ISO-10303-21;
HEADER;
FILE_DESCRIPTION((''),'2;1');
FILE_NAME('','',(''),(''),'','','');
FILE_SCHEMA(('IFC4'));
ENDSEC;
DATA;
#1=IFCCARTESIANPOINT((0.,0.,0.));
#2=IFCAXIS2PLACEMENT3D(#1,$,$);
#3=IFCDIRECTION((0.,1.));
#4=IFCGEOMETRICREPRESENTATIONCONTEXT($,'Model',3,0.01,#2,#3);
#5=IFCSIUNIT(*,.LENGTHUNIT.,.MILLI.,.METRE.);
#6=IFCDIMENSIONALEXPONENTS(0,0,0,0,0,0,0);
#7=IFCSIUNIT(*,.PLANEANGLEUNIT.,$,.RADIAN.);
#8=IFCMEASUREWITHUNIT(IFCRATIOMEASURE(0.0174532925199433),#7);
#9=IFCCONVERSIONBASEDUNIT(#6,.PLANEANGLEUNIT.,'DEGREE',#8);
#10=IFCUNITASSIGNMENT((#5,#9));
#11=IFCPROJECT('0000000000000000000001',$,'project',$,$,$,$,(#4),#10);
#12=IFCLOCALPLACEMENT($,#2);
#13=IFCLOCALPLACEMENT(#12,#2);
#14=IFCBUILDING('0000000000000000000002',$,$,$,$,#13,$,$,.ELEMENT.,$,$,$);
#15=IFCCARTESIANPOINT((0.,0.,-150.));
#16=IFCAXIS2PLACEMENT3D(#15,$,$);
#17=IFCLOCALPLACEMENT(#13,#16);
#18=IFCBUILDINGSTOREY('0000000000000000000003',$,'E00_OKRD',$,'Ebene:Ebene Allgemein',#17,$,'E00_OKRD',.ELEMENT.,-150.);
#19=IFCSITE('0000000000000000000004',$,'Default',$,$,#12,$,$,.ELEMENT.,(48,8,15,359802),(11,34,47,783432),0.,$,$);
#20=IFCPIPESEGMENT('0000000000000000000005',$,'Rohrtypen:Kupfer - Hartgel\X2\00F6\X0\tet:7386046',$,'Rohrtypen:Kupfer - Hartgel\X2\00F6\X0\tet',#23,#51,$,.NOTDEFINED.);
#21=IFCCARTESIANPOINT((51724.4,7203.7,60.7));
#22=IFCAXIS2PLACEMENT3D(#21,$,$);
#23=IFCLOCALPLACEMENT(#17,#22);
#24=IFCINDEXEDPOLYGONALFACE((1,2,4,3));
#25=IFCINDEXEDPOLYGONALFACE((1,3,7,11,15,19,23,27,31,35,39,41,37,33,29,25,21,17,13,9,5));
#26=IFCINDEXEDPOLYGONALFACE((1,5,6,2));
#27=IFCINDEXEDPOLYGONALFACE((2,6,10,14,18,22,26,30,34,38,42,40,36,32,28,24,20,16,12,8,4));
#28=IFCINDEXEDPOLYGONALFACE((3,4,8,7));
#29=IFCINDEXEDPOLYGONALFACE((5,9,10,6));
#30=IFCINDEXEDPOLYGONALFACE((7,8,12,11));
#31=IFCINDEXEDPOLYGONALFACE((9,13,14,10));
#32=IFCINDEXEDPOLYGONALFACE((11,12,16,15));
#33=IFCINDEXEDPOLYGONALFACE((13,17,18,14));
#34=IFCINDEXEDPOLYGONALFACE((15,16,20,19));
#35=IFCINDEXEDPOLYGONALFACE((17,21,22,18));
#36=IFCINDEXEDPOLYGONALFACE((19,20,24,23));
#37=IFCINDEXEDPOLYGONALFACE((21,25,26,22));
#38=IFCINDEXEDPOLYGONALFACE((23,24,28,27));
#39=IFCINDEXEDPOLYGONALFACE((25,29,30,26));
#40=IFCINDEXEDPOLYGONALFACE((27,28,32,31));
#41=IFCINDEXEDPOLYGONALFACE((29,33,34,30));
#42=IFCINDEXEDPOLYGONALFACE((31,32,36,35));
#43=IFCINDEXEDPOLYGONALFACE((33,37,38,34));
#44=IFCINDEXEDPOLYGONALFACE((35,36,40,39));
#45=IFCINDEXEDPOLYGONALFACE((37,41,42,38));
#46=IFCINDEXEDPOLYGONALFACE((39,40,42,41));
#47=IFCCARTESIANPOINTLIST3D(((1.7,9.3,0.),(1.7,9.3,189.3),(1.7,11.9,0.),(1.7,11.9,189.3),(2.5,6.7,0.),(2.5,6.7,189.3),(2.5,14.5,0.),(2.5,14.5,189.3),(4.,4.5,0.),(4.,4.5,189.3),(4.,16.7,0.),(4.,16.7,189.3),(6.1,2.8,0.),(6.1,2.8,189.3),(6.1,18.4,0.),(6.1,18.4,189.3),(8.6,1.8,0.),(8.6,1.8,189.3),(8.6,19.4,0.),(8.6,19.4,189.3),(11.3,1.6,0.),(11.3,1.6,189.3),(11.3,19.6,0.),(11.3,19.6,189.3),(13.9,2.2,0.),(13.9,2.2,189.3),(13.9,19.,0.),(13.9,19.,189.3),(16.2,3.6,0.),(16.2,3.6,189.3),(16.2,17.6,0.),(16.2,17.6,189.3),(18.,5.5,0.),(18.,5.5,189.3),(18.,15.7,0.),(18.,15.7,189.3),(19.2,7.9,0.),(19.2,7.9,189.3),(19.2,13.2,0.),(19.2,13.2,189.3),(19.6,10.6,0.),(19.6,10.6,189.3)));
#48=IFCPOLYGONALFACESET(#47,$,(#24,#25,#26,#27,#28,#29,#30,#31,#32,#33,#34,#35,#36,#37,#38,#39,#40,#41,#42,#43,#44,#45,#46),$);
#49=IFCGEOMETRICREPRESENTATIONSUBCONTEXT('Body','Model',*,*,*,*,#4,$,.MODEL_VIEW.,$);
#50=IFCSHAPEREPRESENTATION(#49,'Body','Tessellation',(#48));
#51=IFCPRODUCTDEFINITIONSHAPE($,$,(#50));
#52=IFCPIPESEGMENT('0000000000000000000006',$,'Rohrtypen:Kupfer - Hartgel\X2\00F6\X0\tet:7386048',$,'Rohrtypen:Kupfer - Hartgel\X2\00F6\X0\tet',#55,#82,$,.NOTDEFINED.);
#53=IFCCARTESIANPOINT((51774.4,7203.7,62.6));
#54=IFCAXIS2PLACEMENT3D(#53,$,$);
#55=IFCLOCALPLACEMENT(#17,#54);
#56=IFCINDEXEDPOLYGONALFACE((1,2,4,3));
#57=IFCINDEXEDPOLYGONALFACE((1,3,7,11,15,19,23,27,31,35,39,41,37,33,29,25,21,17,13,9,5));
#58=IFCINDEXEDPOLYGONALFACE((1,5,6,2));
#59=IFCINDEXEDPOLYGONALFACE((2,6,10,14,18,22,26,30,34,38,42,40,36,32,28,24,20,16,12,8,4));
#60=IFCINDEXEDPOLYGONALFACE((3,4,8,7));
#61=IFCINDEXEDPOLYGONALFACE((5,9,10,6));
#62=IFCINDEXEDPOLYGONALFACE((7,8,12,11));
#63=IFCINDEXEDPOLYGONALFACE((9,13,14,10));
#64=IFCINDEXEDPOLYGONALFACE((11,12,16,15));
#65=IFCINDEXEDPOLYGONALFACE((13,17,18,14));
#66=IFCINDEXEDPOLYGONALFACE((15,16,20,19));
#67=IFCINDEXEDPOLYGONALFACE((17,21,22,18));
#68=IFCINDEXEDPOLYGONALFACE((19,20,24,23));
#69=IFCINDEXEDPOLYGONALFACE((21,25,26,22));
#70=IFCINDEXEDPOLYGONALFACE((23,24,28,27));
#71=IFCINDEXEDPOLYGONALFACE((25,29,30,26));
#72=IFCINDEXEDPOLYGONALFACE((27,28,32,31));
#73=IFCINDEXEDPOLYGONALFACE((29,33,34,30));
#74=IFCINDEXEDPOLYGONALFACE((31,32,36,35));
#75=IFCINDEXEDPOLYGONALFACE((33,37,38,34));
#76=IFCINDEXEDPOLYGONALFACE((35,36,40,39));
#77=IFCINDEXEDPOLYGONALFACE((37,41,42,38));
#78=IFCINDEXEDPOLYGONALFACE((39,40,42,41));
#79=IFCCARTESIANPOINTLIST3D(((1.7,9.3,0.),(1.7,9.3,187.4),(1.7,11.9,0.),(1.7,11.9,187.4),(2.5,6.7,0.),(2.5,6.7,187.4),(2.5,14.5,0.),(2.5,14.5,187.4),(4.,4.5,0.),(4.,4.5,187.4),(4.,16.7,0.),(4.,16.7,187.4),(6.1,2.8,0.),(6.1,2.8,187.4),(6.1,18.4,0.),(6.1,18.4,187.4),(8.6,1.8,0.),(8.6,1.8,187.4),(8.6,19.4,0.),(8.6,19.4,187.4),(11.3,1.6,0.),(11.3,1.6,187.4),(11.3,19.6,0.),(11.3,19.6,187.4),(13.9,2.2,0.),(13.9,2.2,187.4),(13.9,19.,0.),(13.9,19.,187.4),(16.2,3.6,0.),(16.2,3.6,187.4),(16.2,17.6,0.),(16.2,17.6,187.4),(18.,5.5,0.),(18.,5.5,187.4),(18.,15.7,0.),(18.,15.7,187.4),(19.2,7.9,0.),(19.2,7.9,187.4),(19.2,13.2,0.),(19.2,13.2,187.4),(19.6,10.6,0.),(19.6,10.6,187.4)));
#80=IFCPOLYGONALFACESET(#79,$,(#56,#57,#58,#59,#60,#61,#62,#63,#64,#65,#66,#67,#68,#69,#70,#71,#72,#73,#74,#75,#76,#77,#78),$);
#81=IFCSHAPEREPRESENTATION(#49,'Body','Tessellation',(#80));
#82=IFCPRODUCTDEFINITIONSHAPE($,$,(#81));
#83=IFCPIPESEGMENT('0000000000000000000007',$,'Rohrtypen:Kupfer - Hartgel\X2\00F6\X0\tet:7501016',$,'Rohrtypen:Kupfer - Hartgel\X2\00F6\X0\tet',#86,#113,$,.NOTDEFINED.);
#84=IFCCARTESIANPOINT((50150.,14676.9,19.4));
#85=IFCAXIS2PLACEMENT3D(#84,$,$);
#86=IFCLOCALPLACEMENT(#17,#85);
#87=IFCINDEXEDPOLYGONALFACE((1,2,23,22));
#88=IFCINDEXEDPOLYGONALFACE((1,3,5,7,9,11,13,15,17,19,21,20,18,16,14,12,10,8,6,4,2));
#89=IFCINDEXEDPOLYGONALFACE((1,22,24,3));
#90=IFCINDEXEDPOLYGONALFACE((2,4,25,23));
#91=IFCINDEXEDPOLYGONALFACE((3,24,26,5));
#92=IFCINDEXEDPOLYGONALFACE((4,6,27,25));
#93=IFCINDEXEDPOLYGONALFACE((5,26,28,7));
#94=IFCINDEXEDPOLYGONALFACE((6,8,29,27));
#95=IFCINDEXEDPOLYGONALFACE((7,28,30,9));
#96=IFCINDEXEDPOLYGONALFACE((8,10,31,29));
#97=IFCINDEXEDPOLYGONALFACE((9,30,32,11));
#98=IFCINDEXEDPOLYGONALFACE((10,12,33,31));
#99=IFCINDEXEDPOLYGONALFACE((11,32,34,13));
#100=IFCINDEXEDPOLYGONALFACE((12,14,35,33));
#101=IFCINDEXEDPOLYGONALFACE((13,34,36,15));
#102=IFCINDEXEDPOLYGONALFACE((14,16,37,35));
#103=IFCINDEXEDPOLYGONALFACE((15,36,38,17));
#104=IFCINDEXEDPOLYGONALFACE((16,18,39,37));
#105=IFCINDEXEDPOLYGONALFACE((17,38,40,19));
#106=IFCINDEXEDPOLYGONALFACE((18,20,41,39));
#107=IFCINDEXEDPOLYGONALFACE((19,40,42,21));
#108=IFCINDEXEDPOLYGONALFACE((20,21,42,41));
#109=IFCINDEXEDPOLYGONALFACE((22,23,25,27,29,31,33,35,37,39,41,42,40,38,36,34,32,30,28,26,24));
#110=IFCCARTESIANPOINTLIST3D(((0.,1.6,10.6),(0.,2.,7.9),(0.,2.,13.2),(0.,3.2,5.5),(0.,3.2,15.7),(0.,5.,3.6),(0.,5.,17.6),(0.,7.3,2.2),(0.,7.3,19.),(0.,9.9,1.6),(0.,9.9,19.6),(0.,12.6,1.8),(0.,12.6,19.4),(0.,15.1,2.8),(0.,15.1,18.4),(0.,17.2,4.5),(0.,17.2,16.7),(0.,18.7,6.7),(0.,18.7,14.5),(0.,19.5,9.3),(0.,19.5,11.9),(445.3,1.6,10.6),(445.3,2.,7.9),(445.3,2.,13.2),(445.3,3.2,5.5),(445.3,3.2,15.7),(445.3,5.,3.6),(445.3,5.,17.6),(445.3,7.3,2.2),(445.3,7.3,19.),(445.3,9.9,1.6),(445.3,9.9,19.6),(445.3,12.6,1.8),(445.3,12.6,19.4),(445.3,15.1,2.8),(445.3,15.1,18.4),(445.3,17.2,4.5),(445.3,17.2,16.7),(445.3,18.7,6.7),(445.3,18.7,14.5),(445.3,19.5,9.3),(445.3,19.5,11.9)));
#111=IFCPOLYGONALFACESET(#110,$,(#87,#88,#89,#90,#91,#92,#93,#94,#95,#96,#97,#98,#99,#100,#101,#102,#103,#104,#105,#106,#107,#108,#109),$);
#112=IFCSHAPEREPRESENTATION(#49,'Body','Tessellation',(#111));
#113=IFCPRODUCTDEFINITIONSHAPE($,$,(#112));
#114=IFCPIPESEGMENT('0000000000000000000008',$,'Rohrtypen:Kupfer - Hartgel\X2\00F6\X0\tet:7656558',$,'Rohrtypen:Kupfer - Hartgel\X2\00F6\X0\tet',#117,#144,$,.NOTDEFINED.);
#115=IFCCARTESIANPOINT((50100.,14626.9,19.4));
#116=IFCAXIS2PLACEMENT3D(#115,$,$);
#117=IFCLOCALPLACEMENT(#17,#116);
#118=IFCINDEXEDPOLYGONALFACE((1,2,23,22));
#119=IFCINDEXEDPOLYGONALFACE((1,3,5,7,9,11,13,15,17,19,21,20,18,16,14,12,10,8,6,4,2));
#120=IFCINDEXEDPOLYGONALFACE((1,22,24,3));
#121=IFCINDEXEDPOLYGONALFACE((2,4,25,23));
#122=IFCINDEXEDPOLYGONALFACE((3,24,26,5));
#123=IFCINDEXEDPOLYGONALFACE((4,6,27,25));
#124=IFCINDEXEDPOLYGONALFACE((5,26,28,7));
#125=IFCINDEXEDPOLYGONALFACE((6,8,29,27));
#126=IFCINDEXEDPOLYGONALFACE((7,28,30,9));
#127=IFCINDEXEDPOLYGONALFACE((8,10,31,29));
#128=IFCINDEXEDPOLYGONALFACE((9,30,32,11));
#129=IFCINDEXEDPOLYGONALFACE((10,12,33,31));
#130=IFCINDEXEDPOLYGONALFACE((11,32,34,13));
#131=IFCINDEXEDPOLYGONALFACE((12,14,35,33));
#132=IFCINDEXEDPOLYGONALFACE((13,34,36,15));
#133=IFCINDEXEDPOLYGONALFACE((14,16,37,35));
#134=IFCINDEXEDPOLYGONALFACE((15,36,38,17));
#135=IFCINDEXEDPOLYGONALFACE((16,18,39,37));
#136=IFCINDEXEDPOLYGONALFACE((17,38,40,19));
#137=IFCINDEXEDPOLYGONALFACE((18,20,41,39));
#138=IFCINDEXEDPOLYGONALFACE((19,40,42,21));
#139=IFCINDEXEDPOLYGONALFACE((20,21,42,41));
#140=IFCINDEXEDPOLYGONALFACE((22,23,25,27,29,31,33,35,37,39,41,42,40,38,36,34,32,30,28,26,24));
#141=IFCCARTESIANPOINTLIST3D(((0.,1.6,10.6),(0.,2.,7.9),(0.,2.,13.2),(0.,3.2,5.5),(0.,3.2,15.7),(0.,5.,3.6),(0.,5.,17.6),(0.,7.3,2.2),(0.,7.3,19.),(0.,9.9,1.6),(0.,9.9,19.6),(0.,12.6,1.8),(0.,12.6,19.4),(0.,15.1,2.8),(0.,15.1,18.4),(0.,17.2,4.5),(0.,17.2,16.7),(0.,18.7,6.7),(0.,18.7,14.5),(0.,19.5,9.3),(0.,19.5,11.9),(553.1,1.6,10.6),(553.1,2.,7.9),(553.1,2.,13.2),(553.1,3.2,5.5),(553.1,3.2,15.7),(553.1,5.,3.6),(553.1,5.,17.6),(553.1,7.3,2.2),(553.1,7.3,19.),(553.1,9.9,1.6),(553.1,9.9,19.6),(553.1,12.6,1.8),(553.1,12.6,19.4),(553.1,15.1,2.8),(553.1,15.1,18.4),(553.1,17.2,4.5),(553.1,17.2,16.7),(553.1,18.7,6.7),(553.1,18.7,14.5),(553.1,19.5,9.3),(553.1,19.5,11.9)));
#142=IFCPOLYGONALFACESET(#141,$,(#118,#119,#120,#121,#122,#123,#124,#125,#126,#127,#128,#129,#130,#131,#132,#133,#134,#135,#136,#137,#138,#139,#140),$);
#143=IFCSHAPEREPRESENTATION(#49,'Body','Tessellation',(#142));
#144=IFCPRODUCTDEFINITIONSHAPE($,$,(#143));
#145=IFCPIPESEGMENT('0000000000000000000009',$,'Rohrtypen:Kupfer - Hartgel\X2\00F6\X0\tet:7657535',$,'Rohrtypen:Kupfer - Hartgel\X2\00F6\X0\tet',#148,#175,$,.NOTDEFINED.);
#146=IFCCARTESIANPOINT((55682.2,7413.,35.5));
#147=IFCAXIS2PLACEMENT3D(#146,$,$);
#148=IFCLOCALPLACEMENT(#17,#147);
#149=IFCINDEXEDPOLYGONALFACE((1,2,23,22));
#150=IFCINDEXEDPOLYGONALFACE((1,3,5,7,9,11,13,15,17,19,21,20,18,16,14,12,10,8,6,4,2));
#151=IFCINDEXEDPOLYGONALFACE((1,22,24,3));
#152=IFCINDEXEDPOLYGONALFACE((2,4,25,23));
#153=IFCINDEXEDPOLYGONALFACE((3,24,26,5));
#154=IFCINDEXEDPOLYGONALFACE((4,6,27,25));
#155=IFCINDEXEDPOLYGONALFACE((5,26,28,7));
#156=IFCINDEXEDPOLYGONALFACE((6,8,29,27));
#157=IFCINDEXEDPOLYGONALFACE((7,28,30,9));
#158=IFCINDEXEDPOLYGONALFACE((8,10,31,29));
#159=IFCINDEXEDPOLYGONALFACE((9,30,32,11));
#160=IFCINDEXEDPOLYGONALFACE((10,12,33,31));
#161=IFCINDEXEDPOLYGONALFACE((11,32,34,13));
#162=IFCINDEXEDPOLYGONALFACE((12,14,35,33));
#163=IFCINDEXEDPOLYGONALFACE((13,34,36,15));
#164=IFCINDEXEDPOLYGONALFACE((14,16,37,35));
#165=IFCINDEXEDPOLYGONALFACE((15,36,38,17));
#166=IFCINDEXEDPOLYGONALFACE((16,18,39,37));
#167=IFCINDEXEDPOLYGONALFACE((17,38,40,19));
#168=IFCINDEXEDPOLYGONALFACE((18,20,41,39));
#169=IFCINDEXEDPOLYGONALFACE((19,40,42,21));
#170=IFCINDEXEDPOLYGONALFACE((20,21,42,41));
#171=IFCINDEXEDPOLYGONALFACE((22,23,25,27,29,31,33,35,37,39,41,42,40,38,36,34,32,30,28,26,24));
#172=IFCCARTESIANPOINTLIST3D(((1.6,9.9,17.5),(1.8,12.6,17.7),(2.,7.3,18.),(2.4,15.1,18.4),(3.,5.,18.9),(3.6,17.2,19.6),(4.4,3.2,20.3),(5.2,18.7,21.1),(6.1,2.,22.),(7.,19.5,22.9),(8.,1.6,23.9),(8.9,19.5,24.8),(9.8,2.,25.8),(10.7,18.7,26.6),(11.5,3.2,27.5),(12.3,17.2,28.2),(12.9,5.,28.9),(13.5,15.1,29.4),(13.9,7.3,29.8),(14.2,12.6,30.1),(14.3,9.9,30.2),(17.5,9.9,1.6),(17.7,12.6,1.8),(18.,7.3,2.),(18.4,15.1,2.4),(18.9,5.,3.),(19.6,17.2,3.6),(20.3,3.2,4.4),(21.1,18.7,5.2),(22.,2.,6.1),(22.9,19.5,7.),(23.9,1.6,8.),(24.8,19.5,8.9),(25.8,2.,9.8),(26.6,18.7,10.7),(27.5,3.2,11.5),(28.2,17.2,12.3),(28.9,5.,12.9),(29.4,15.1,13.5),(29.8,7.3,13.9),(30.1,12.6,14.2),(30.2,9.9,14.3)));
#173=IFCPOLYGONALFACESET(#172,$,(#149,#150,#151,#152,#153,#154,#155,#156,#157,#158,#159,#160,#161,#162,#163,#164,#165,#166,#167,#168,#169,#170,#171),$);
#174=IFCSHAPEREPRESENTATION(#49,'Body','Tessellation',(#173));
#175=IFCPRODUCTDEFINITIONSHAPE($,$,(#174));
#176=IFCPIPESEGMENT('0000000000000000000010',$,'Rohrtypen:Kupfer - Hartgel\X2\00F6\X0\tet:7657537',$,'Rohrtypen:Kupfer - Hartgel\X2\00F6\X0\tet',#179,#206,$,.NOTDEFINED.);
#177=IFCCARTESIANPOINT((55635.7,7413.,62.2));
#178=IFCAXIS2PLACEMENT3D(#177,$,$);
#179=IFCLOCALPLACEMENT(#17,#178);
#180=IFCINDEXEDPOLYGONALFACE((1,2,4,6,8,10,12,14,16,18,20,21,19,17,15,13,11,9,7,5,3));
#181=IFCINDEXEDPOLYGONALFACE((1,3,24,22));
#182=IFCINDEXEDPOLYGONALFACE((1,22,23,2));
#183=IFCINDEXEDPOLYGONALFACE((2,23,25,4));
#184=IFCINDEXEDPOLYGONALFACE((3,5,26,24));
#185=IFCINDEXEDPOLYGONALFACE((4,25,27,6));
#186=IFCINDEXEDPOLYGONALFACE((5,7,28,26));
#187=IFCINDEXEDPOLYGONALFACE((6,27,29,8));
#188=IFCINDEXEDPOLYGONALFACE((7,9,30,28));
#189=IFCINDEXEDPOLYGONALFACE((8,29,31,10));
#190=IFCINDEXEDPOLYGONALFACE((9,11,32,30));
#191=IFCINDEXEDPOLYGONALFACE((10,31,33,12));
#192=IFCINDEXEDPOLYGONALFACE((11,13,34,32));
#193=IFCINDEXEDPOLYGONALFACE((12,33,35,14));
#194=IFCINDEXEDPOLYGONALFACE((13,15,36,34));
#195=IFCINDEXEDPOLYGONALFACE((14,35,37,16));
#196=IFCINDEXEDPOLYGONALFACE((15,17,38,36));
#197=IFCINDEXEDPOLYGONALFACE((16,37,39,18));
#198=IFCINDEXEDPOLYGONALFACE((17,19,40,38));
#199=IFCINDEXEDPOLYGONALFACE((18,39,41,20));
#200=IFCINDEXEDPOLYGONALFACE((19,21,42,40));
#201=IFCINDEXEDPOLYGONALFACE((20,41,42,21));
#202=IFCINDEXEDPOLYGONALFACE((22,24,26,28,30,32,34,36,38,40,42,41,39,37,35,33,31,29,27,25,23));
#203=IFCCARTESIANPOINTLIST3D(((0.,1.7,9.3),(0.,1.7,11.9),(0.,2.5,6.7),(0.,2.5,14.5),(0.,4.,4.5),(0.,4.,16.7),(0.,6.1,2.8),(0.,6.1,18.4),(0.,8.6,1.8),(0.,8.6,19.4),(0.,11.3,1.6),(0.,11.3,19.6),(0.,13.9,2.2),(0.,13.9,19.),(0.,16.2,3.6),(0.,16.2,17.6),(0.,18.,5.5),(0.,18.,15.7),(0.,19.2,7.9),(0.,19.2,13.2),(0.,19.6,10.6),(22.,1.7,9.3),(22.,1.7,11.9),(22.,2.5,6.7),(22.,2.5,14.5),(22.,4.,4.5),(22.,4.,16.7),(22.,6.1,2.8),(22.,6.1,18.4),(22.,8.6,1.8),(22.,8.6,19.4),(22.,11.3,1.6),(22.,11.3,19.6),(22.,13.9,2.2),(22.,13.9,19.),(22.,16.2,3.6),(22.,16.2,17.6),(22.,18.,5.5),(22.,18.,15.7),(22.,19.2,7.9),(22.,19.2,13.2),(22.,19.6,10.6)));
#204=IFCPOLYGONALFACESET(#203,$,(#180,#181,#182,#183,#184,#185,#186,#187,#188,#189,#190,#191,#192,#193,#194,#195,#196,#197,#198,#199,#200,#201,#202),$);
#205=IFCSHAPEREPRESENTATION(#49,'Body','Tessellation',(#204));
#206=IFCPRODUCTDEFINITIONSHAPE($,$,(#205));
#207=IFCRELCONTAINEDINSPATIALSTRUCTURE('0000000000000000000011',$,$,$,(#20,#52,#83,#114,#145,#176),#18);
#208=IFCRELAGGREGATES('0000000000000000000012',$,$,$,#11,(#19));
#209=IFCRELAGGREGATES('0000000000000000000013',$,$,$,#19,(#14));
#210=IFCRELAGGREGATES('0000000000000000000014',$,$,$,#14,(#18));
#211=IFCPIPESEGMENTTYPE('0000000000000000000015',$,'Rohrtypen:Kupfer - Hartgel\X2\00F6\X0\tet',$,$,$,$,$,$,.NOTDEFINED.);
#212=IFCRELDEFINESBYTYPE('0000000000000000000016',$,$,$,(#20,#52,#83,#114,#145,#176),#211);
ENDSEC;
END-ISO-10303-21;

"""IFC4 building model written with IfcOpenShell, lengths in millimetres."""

from ifc_helpers import new_model, entity, si_unit, converted_unit, direction, frame, frame_2d, origin, origin_2d_with_axis, place, context, subcontext, project, spatial, circle, extrude, type_object, element, save


model = new_model("IFC4")

# Units and contexts
model_context = context("Model", 3, precision=0.01, world=origin(), true_north=direction((0.0, 1.0)))
body_context = subcontext(model_context, "Body", "Model", "MODEL_VIEW")
ifc_project = project(units=[si_unit("LENGTHUNIT", "METRE", prefix="MILLI"), converted_unit("PLANEANGLEUNIT", "DEGREE", entity("IfcRatioMeasure", 0.0174532925199433), si_unit("PLANEANGLEUNIT", "RADIAN"), dimensions=[0, 0, 0, 0, 0, 0, 0])], contexts=[model_context])

# Site, building, storey
site_placement = place(None, origin())
site = spatial("IfcSite", under=ifc_project, at=site_placement, Name="Default", CompositionType="ELEMENT", RefLatitude=(48, 8, 15, 359802), RefLongitude=(11, 34, 47, 783432), RefElevation=0.0)
building_placement = place(site_placement, origin())
building = spatial("IfcBuilding", under=site, at=building_placement, CompositionType="ELEMENT")
storey_placement = place(building_placement, frame((0.0, 0.0, -150.0)))
storey = spatial("IfcBuildingStorey", under=building, at=storey_placement, Name="E00_OKRD", ObjectType="Ebene:Ebene Allgemein", LongName="E00_OKRD", CompositionType="ELEMENT", Elevation=-150.0)

# Pipe segments
pipe_segment_type = type_object("IfcPipeSegmentType", Name="Rohrtypen:Kupfer - Hartgelötet", PredefinedType="NOTDEFINED")
pipe_segment_1_placement = place(storey_placement, frame((51724.4, 7203.7, 60.7)))
element("IfcPipeSegment", 1, at=pipe_segment_1_placement, inside=storey, type_object=pipe_segment_type, Name="Rohrtypen:Kupfer - Hartgelötet:7386046", ObjectType="Rohrtypen:Kupfer - Hartgelötet", PredefinedType="NOTDEFINED", context=body_context, shape_type="SweptSolid", body=[
    extrude(circle(Radius=9.0, at=origin_2d_with_axis()), frame((10.6, 10.6, 0.0)), (0.0, 0.0, 1.0), 189.3),
])
pipe_segment_2_placement = place(storey_placement, frame((51774.4, 7203.7, 62.6)))
element("IfcPipeSegment", 2, at=pipe_segment_2_placement, inside=storey, type_object=pipe_segment_type, Name="Rohrtypen:Kupfer - Hartgelötet:7386048", ObjectType="Rohrtypen:Kupfer - Hartgelötet", PredefinedType="NOTDEFINED", context=body_context, shape_type="SweptSolid", body=[
    extrude(circle(Radius=9.0, at=origin_2d_with_axis()), frame((10.6, 10.6, 0.0)), (0.0, 0.0, 1.0), 187.4),
])
pipe_segment_3_placement = place(storey_placement, frame((50150.0, 14676.9, 19.4)))
element("IfcPipeSegment", 3, at=pipe_segment_3_placement, inside=storey, type_object=pipe_segment_type, Name="Rohrtypen:Kupfer - Hartgelötet:7501016", ObjectType="Rohrtypen:Kupfer - Hartgelötet", PredefinedType="NOTDEFINED", context=body_context, shape_type="SweptSolid", body=[
    extrude(circle(Radius=9.0, at=origin_2d_with_axis()), frame((0.0, 10.6, 10.6), z_axis=(1.0, 0.0, 0.0), x_axis=(0.0, -1.0, 0.0)), (0.0, 0.0, 1.0), 445.3),
])
pipe_segment_4_placement = place(storey_placement, frame((50100.0, 14626.9, 19.4)))
element("IfcPipeSegment", 4, at=pipe_segment_4_placement, inside=storey, type_object=pipe_segment_type, Name="Rohrtypen:Kupfer - Hartgelötet:7656558", ObjectType="Rohrtypen:Kupfer - Hartgelötet", PredefinedType="NOTDEFINED", context=body_context, shape_type="SweptSolid", body=[
    extrude(circle(Radius=9.0, at=frame_2d((0.0, 0.0), x_axis=(1.0, 0.0))), frame((0.0, 10.6, 10.6), z_axis=(1.0, 0.0, 0.0), x_axis=(0.0, -1.0, 0.0)), (0.0, 0.0, 1.0), 553.1),
])
pipe_segment_5_placement = place(storey_placement, frame((55682.2, 7413.0, 35.5)))
element("IfcPipeSegment", 5, at=pipe_segment_5_placement, inside=storey, type_object=pipe_segment_type, Name="Rohrtypen:Kupfer - Hartgelötet:7657535", ObjectType="Rohrtypen:Kupfer - Hartgelötet", PredefinedType="NOTDEFINED", context=body_context, shape_type="SweptSolid", body=[
    extrude(circle(Radius=9.0, at=frame_2d((0.0, 0.0), x_axis=(1.0, 0.0))), frame((8.0, 10.6, 23.9), z_axis=(0.707107, 0.0, -0.707107), x_axis=(0.0, -1.0, 0.0)), (0.0, 0.0, 1.0), 22.5),
])
pipe_segment_6_placement = place(storey_placement, frame((55635.7, 7413.0, 62.2)))
element("IfcPipeSegment", 6, at=pipe_segment_6_placement, inside=storey, type_object=pipe_segment_type, Name="Rohrtypen:Kupfer - Hartgelötet:7657537", ObjectType="Rohrtypen:Kupfer - Hartgelötet", PredefinedType="NOTDEFINED", context=body_context, shape_type="SweptSolid", body=[
    extrude(circle(Radius=9.0, at=origin_2d_with_axis()), frame((0.0, 10.6, 10.6), z_axis=(1.0, 0.0, 0.0), x_axis=(0.0, 1.0, 0.0)), (0.0, 0.0, 1.0), 22.0),
])

save(model, "model.ifc")
